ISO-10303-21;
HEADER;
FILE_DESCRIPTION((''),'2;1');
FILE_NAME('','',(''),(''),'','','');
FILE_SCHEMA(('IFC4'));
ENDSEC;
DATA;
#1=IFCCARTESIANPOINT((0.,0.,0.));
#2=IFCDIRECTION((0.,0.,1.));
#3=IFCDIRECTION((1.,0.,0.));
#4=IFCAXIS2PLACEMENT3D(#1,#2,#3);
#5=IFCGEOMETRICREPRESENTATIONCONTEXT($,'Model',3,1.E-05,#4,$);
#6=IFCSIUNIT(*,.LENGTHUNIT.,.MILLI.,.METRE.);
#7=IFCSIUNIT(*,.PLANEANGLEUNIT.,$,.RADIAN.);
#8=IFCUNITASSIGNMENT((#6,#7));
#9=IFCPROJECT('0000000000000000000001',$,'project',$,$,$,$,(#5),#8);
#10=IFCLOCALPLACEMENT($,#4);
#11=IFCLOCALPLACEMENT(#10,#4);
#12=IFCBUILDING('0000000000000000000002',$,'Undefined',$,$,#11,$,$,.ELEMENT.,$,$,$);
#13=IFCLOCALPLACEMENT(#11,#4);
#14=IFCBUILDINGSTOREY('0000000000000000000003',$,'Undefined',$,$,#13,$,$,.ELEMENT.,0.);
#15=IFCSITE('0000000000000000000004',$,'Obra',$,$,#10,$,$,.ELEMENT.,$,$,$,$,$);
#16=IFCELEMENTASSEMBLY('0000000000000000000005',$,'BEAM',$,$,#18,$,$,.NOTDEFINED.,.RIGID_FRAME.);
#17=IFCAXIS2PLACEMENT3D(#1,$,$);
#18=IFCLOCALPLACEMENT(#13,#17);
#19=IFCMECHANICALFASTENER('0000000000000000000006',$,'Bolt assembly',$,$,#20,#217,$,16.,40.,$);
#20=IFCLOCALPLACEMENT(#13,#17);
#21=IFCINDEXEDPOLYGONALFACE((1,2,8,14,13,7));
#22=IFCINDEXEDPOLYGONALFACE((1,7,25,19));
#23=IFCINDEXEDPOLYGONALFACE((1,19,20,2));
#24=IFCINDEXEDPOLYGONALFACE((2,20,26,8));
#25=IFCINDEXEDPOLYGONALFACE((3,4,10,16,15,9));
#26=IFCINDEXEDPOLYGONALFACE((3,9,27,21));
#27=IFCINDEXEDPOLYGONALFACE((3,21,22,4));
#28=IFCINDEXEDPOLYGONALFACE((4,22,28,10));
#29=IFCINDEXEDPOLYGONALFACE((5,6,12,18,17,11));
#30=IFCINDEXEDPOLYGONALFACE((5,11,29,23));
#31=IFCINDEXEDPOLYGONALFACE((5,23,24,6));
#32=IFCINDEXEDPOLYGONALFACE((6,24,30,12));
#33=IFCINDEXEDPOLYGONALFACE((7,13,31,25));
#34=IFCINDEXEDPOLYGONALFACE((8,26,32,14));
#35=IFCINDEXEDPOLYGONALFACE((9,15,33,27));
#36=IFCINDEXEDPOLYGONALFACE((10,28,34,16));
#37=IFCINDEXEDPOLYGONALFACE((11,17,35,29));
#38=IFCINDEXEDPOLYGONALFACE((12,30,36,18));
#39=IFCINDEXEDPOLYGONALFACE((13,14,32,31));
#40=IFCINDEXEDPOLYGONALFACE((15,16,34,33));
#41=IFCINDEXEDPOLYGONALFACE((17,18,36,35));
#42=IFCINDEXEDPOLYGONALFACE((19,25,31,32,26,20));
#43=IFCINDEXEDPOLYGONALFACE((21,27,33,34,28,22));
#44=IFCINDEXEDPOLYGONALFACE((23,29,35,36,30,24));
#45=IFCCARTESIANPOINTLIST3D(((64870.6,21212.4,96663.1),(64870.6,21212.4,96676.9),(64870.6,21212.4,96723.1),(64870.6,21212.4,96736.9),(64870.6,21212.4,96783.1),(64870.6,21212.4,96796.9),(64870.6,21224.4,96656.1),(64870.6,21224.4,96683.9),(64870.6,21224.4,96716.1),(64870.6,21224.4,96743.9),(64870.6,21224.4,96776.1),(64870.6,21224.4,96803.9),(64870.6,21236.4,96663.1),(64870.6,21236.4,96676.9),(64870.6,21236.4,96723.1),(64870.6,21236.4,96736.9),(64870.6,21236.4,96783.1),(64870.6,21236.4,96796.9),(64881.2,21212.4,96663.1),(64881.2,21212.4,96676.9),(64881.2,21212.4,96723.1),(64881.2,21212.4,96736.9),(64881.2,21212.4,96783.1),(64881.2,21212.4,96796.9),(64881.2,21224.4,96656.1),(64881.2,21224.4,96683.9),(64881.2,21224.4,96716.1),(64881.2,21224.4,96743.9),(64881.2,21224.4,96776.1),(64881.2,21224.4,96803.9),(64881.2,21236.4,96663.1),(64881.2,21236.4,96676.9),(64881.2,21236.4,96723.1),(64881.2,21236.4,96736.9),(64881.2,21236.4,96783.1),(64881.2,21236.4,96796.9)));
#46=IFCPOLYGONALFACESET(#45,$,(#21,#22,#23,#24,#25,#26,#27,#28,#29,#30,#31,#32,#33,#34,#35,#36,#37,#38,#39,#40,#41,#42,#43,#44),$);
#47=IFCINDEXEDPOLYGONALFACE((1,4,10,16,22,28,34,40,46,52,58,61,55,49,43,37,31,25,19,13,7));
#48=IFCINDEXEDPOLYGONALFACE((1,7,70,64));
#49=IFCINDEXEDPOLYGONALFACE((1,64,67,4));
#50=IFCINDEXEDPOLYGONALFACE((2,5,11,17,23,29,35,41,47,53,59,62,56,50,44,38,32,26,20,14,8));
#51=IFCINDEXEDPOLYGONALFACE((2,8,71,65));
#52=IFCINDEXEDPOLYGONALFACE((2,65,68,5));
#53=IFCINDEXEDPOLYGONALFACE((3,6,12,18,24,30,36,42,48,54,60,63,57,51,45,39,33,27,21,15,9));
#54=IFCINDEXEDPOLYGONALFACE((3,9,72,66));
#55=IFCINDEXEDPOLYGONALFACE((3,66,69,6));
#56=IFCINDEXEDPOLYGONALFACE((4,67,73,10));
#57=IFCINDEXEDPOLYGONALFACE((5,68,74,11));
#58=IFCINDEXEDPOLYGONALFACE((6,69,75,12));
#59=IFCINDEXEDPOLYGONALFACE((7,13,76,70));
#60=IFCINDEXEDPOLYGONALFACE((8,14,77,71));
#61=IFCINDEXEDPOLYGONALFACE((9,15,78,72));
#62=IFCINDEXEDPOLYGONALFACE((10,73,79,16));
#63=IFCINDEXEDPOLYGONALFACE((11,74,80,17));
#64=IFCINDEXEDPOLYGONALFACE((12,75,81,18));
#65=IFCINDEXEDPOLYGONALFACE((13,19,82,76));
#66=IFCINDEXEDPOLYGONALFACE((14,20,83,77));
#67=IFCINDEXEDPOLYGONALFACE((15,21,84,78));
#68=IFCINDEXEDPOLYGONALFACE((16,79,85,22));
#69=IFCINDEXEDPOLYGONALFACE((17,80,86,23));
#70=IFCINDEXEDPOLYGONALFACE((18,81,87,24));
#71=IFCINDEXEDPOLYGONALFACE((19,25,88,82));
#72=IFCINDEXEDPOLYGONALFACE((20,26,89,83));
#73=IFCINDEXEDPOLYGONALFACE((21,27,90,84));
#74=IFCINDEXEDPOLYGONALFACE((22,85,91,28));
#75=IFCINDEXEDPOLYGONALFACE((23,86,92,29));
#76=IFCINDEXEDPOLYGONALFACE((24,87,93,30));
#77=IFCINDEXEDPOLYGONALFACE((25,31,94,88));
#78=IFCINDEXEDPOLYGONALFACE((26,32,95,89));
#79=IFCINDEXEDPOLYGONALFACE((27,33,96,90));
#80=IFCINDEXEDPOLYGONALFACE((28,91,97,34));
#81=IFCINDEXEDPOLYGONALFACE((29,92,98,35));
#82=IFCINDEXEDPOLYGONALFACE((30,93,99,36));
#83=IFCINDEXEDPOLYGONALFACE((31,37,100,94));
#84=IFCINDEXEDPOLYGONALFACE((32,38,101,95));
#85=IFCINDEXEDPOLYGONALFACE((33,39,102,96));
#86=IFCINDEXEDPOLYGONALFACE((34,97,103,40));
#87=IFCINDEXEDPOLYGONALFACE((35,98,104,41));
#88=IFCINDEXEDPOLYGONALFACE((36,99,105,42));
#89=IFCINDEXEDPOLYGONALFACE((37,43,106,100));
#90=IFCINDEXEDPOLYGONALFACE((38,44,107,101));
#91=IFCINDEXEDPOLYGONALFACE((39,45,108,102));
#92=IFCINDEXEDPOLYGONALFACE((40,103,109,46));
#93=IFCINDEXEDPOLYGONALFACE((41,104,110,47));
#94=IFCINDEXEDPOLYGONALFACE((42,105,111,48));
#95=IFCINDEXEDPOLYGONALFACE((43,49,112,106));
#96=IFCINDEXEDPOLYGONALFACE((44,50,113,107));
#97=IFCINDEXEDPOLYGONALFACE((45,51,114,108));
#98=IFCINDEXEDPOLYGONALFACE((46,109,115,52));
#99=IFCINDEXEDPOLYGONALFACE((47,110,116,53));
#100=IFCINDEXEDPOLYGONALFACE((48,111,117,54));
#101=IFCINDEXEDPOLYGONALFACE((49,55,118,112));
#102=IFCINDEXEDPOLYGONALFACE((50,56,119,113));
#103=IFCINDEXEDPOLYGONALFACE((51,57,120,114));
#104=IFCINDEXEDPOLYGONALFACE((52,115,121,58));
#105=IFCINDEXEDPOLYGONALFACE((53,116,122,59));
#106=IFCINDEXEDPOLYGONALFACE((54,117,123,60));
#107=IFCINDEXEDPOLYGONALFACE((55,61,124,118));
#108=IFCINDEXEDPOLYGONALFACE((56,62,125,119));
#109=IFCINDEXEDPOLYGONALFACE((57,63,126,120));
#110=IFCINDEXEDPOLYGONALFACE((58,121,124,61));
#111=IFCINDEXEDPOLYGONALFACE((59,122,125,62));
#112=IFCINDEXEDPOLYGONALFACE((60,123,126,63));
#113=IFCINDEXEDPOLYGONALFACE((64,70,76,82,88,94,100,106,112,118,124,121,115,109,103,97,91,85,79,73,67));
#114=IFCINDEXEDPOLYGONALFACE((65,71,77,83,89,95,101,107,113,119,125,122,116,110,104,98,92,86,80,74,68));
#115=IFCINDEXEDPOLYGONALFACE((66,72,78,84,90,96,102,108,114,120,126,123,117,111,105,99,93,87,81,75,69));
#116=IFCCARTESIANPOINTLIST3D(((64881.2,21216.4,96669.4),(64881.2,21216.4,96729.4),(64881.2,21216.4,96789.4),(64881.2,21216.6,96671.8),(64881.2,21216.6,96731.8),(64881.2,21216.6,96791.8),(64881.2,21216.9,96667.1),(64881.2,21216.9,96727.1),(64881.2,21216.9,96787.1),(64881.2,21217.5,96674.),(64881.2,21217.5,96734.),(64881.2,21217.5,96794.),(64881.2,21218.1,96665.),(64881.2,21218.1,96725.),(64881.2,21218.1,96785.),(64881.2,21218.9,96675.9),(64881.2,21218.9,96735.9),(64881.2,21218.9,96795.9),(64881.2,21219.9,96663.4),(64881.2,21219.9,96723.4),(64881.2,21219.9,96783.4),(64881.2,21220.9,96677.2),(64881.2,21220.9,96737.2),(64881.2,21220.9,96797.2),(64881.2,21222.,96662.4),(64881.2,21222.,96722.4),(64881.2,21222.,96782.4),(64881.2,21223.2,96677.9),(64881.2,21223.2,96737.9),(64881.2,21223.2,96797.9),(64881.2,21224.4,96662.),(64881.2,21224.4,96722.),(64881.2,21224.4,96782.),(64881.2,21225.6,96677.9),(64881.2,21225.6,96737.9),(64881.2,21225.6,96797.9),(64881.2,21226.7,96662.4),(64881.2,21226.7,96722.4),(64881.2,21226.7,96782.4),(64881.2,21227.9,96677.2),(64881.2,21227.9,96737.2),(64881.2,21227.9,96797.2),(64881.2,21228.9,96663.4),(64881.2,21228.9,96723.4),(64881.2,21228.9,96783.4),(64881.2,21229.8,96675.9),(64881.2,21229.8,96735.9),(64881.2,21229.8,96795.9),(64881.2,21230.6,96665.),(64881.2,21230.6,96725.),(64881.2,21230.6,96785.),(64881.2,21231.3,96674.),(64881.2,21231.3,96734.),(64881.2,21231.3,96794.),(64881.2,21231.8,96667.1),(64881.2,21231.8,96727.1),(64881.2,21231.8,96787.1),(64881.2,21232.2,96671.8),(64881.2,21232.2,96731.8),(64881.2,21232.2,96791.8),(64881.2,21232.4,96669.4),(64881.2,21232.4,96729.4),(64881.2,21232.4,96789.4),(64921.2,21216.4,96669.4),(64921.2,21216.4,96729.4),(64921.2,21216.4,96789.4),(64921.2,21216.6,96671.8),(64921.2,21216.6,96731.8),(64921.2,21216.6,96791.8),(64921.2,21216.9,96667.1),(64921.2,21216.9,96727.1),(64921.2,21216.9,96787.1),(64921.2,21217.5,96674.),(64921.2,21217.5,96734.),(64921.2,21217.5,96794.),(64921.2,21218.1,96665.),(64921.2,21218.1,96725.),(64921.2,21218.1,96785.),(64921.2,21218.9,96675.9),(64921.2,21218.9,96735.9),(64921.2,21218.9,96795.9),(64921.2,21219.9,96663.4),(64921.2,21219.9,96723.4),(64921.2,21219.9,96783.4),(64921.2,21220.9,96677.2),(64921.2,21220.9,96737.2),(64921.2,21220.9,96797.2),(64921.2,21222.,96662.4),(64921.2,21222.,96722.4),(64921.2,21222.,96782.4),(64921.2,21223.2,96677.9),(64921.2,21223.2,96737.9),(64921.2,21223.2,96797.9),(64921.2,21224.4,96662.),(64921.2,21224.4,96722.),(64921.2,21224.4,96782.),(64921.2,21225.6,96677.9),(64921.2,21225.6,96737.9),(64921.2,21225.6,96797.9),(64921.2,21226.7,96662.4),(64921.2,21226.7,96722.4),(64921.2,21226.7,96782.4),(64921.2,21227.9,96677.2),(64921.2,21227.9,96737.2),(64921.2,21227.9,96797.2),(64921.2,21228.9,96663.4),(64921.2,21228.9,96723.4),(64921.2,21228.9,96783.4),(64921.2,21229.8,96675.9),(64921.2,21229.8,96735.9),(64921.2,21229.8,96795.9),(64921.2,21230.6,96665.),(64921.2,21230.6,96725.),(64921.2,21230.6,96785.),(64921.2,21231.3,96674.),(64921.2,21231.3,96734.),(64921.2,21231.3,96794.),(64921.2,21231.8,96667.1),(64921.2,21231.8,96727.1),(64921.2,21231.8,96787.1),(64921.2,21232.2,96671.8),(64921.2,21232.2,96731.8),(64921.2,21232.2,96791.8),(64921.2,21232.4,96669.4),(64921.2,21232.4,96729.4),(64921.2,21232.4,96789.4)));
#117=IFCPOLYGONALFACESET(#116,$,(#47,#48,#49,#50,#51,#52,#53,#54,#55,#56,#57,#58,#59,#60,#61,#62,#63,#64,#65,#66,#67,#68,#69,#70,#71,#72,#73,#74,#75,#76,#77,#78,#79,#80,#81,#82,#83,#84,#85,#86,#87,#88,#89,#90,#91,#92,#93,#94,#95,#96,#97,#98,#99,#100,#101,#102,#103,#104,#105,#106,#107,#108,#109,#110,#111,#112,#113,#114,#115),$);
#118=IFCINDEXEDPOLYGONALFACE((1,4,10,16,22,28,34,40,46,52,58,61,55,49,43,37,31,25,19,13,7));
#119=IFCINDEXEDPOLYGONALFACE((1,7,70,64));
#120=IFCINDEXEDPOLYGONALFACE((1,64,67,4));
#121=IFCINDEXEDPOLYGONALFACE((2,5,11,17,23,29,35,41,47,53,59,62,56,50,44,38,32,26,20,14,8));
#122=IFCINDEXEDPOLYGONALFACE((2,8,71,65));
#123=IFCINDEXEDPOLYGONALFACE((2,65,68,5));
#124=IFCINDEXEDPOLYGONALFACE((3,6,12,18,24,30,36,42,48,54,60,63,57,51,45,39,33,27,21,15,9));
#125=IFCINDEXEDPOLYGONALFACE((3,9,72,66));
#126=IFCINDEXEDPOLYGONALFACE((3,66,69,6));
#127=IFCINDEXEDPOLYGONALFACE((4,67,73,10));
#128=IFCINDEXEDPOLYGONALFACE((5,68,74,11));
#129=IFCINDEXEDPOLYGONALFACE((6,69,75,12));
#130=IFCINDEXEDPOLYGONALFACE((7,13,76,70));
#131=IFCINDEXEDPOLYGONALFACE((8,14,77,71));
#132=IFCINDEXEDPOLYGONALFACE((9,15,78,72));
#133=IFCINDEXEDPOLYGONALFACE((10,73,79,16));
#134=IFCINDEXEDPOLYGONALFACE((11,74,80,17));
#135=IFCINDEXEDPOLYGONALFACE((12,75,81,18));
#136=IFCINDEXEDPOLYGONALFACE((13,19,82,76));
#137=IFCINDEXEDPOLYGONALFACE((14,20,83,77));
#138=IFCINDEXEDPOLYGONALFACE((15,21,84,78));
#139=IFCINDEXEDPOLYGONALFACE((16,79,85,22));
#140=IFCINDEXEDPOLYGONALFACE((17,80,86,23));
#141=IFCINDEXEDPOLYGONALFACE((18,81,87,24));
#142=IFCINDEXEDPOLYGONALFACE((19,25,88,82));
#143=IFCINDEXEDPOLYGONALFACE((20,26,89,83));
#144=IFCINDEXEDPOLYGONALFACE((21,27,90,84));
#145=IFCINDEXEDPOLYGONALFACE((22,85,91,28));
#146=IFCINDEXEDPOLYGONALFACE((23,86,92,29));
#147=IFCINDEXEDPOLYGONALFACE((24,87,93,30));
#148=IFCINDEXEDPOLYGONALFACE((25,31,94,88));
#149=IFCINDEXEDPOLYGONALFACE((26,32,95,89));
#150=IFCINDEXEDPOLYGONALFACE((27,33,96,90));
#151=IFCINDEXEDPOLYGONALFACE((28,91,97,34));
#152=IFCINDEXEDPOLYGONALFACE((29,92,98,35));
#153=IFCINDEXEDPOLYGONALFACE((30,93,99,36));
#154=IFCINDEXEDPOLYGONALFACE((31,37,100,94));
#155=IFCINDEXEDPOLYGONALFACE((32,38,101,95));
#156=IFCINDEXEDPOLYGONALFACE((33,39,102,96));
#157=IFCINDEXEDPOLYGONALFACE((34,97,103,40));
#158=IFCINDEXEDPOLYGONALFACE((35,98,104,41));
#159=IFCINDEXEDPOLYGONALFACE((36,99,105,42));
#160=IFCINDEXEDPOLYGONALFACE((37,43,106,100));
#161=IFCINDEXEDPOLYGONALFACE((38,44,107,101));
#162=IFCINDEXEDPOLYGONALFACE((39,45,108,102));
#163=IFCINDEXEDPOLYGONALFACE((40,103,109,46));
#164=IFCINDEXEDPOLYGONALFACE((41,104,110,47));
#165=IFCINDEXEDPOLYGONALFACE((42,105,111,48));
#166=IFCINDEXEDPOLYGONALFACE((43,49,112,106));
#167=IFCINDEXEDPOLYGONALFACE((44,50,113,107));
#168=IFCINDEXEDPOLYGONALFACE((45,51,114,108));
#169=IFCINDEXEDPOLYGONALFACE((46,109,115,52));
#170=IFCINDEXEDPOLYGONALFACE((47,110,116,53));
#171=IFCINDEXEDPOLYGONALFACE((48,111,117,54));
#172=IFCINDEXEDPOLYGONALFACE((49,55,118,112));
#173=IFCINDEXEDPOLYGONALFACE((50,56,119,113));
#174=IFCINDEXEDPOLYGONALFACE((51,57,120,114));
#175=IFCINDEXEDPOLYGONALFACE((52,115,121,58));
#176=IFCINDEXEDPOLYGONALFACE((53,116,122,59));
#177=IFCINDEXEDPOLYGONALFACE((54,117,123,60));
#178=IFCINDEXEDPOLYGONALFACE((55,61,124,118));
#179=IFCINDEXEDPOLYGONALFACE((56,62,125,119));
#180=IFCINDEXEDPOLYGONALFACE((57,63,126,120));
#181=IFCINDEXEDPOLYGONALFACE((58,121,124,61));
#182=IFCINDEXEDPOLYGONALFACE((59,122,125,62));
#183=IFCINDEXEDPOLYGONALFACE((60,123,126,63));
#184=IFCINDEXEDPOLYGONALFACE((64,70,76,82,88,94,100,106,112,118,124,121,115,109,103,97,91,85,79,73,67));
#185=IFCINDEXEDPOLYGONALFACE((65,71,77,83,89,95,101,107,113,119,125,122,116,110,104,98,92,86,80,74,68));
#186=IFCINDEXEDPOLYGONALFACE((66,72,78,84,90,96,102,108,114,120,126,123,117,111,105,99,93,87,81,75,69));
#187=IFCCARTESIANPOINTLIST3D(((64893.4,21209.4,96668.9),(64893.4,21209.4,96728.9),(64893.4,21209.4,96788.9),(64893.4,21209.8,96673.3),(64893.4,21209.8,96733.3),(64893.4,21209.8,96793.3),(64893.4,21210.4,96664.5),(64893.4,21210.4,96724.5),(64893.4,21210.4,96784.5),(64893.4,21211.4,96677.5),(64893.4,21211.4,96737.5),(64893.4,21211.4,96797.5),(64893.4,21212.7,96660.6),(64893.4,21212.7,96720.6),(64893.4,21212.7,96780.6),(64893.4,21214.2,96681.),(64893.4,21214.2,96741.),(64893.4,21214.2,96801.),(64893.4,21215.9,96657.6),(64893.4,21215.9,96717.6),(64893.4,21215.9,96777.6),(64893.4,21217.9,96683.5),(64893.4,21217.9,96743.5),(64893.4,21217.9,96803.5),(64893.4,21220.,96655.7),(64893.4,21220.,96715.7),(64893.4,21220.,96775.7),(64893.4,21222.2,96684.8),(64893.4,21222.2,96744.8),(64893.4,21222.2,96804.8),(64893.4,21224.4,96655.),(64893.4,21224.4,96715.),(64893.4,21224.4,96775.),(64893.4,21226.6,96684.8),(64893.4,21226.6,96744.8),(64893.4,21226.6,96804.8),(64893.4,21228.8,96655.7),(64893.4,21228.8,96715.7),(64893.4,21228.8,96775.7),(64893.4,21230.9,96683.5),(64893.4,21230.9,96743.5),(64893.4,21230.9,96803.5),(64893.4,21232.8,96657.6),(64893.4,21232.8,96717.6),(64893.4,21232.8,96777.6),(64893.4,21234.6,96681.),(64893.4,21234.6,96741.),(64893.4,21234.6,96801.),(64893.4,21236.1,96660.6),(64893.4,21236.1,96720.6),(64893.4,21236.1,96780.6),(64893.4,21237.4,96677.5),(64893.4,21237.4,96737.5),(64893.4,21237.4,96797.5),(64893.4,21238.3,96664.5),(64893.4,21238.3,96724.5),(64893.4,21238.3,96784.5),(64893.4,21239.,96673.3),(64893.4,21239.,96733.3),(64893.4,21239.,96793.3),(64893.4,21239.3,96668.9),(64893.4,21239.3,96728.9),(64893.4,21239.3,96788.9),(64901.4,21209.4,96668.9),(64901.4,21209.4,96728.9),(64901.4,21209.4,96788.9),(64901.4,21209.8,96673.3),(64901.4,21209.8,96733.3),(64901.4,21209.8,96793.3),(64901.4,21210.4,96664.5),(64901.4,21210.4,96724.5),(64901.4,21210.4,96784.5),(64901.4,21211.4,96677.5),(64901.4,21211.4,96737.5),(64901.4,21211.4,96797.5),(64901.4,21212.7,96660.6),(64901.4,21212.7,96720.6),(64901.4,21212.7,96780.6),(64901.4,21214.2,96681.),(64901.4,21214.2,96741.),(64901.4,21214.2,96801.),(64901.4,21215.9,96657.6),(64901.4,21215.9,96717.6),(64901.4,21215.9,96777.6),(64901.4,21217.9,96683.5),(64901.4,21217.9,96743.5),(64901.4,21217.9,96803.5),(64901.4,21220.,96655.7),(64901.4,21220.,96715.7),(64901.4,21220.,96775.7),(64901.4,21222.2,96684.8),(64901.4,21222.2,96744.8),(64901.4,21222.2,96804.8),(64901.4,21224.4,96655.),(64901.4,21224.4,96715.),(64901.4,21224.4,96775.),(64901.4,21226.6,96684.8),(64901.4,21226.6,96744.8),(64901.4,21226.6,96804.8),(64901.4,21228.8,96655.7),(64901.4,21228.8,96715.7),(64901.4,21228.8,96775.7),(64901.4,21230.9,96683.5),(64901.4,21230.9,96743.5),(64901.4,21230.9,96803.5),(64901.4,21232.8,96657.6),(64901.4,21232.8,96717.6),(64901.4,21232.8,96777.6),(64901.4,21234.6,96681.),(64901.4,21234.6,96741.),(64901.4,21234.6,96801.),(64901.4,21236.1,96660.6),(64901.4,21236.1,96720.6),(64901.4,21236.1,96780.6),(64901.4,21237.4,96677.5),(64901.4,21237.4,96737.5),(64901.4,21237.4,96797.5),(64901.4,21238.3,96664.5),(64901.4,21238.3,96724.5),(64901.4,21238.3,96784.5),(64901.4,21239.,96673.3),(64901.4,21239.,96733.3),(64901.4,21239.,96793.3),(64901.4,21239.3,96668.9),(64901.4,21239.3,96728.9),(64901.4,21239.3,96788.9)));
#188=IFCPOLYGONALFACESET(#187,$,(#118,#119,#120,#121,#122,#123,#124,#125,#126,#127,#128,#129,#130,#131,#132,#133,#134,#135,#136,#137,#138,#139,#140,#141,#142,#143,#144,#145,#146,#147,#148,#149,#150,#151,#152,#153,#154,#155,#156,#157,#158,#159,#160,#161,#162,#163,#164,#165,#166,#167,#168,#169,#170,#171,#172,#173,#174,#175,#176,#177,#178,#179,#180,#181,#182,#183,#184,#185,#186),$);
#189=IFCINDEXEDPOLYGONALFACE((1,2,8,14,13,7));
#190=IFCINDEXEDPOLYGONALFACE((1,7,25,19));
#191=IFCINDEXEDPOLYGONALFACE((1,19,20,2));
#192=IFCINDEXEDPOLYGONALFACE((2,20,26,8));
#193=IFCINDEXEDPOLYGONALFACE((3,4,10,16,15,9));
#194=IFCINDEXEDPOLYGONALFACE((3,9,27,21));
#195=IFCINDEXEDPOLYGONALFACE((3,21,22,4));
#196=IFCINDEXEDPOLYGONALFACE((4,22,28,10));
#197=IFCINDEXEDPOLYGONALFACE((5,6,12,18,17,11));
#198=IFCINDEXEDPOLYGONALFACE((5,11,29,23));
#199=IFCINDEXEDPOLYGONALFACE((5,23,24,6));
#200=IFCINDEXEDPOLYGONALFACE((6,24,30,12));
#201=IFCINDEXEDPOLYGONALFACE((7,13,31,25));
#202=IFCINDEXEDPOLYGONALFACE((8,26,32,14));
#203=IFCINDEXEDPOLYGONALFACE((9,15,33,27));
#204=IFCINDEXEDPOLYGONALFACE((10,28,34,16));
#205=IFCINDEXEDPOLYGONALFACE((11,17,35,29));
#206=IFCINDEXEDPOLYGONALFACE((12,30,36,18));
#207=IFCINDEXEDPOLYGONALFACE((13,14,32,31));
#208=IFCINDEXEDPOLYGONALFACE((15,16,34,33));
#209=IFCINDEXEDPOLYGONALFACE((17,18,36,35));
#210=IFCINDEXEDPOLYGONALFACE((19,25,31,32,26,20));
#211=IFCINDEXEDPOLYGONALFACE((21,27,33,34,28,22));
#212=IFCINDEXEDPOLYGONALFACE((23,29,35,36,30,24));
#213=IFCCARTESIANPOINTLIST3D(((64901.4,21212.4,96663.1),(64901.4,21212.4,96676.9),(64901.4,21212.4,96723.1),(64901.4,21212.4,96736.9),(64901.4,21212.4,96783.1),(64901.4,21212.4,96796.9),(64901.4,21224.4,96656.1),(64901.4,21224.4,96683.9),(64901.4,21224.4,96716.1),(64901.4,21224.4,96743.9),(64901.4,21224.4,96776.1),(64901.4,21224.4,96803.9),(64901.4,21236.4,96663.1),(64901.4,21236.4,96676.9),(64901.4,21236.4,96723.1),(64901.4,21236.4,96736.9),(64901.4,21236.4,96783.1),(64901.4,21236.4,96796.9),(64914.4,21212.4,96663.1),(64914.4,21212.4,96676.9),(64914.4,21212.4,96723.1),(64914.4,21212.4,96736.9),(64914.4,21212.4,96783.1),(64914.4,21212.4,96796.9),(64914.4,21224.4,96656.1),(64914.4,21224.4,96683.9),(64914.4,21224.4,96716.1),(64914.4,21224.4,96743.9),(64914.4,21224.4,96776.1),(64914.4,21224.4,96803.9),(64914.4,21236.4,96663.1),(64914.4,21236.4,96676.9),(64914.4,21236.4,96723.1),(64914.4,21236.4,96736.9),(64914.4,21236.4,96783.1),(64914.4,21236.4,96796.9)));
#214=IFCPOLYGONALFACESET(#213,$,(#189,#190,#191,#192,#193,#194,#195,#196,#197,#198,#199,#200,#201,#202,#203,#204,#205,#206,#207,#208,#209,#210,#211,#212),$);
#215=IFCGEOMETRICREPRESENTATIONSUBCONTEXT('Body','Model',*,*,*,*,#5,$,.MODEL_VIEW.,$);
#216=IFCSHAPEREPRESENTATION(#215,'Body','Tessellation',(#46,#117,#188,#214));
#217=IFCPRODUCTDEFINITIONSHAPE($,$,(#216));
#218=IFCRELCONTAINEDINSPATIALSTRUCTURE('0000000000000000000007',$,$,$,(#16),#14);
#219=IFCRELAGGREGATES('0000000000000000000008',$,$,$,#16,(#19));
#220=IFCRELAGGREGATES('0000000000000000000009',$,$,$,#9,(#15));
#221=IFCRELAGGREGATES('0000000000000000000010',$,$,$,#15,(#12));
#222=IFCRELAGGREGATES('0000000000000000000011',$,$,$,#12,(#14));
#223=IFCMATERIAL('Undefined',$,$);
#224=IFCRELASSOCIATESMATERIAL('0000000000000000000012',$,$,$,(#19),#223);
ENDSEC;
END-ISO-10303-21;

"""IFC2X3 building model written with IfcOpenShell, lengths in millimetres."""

from ifc_helpers import new_model, si_unit, frame, origin_with_axes, origin_2d_with_axis, place, context, subcontext, project, spatial, polyline, circle, outline, extrude, source, transform, mapped, material, element, aggregate, save


model = new_model("IFC2X3")

# Units and contexts
model_context = context("Model", 3, precision=1e-05, world=origin_with_axes())
body_context = subcontext(model_context, "Body", "Model", "MODEL_VIEW")
ifc_project = project(units=[si_unit("LENGTHUNIT", "METRE", prefix="MILLI"), si_unit("PLANEANGLEUNIT", "RADIAN")], contexts=[model_context])

# Site, building, storey
site_placement = place(None, origin_with_axes())
site = spatial("IfcSite", under=ifc_project, at=site_placement, Name="Obra", CompositionType="ELEMENT")
building_placement = place(site_placement, origin_with_axes())
building = spatial("IfcBuilding", under=site, at=building_placement, Name="Undefined", CompositionType="ELEMENT")
storey_placement = place(building_placement, origin_with_axes())
storey = spatial("IfcBuildingStorey", under=building, at=storey_placement, Name="Undefined", CompositionType="ELEMENT", Elevation=0.0)

# Shared definitions
ifc_material_1 = material(Name="Undefined")

# Element assembly, mechanical fastener
assembly_1_placement = place(storey_placement, origin_with_axes())
assembly_1 = element("IfcElementAssembly", 1, at=assembly_1_placement, inside=storey, Name="BEAM", AssemblyPlace="NOTDEFINED", PredefinedType="RIGID_FRAME")
shared_shape_1 = source(origin_with_axes(), body_context, "Body", "SweptSolid", [
    extrude(outline(polyline([(13.9, 0.0), (6.9, 12.0), (-6.9, 12.0), (-13.9, 0.0), (-6.9, -12.0), (6.9, -12.0), (13.9, 0.0)])), frame((0.0, -19.7, 0.0), z_axis=(0.0, 1.0, 0.0), x_axis=(1.0, 0.0, 0.0)), (0.0, 0.0, 1.0), 10.6),
    extrude(circle(Radius=8.0, at=origin_2d_with_axis()), frame((0.0, -9.1, 0.0), z_axis=(0.0, 1.0, 0.0), x_axis=(1.0, 0.0, 0.0)), (0.0, 0.0, 1.0), 40.0),
    extrude(circle(Radius=15.0, at=origin_2d_with_axis()), frame((0.0, 3.1, 0.0), z_axis=(0.0, 1.0, 0.0), x_axis=(1.0, 0.0, 0.0)), (0.0, 0.0, 1.0), 8.0),
    extrude(outline(polyline([(13.9, 0.0), (6.9, 12.0), (-6.9, 12.0), (-13.9, 0.0), (-6.9, -12.0), (6.9, -12.0), (13.9, 0.0)])), frame((0.0, 11.1, 0.0), z_axis=(0.0, 1.0, 0.0), x_axis=(1.0, 0.0, 0.0)), (0.0, 0.0, 1.0), 13.0),
])
mechanical_fastener_1_placement = place(assembly_1_placement, frame((64890.3, 21274.4, 96850.0), z_axis=(0.000002, -1.0, 0.0), x_axis=(0.0, 0.0, -1.0)))
mechanical_fastener_1 = element("IfcMechanicalFastener", 2, at=mechanical_fastener_1_placement, material=ifc_material_1, Name="Bolt assembly", NominalDiameter=16.0, NominalLength=40.0, context=body_context, shape_type="MappedRepresentation", body=[
    mapped(shared_shape_1, transform((60.0, 0.0, 50.0))),
    mapped(shared_shape_1, transform((120.0, 0.0, 50.0))),
    mapped(shared_shape_1, transform((180.0, 0.0, 50.0))),
])
aggregate(assembly_1, [mechanical_fastener_1])

save(model, "model.ifc")
